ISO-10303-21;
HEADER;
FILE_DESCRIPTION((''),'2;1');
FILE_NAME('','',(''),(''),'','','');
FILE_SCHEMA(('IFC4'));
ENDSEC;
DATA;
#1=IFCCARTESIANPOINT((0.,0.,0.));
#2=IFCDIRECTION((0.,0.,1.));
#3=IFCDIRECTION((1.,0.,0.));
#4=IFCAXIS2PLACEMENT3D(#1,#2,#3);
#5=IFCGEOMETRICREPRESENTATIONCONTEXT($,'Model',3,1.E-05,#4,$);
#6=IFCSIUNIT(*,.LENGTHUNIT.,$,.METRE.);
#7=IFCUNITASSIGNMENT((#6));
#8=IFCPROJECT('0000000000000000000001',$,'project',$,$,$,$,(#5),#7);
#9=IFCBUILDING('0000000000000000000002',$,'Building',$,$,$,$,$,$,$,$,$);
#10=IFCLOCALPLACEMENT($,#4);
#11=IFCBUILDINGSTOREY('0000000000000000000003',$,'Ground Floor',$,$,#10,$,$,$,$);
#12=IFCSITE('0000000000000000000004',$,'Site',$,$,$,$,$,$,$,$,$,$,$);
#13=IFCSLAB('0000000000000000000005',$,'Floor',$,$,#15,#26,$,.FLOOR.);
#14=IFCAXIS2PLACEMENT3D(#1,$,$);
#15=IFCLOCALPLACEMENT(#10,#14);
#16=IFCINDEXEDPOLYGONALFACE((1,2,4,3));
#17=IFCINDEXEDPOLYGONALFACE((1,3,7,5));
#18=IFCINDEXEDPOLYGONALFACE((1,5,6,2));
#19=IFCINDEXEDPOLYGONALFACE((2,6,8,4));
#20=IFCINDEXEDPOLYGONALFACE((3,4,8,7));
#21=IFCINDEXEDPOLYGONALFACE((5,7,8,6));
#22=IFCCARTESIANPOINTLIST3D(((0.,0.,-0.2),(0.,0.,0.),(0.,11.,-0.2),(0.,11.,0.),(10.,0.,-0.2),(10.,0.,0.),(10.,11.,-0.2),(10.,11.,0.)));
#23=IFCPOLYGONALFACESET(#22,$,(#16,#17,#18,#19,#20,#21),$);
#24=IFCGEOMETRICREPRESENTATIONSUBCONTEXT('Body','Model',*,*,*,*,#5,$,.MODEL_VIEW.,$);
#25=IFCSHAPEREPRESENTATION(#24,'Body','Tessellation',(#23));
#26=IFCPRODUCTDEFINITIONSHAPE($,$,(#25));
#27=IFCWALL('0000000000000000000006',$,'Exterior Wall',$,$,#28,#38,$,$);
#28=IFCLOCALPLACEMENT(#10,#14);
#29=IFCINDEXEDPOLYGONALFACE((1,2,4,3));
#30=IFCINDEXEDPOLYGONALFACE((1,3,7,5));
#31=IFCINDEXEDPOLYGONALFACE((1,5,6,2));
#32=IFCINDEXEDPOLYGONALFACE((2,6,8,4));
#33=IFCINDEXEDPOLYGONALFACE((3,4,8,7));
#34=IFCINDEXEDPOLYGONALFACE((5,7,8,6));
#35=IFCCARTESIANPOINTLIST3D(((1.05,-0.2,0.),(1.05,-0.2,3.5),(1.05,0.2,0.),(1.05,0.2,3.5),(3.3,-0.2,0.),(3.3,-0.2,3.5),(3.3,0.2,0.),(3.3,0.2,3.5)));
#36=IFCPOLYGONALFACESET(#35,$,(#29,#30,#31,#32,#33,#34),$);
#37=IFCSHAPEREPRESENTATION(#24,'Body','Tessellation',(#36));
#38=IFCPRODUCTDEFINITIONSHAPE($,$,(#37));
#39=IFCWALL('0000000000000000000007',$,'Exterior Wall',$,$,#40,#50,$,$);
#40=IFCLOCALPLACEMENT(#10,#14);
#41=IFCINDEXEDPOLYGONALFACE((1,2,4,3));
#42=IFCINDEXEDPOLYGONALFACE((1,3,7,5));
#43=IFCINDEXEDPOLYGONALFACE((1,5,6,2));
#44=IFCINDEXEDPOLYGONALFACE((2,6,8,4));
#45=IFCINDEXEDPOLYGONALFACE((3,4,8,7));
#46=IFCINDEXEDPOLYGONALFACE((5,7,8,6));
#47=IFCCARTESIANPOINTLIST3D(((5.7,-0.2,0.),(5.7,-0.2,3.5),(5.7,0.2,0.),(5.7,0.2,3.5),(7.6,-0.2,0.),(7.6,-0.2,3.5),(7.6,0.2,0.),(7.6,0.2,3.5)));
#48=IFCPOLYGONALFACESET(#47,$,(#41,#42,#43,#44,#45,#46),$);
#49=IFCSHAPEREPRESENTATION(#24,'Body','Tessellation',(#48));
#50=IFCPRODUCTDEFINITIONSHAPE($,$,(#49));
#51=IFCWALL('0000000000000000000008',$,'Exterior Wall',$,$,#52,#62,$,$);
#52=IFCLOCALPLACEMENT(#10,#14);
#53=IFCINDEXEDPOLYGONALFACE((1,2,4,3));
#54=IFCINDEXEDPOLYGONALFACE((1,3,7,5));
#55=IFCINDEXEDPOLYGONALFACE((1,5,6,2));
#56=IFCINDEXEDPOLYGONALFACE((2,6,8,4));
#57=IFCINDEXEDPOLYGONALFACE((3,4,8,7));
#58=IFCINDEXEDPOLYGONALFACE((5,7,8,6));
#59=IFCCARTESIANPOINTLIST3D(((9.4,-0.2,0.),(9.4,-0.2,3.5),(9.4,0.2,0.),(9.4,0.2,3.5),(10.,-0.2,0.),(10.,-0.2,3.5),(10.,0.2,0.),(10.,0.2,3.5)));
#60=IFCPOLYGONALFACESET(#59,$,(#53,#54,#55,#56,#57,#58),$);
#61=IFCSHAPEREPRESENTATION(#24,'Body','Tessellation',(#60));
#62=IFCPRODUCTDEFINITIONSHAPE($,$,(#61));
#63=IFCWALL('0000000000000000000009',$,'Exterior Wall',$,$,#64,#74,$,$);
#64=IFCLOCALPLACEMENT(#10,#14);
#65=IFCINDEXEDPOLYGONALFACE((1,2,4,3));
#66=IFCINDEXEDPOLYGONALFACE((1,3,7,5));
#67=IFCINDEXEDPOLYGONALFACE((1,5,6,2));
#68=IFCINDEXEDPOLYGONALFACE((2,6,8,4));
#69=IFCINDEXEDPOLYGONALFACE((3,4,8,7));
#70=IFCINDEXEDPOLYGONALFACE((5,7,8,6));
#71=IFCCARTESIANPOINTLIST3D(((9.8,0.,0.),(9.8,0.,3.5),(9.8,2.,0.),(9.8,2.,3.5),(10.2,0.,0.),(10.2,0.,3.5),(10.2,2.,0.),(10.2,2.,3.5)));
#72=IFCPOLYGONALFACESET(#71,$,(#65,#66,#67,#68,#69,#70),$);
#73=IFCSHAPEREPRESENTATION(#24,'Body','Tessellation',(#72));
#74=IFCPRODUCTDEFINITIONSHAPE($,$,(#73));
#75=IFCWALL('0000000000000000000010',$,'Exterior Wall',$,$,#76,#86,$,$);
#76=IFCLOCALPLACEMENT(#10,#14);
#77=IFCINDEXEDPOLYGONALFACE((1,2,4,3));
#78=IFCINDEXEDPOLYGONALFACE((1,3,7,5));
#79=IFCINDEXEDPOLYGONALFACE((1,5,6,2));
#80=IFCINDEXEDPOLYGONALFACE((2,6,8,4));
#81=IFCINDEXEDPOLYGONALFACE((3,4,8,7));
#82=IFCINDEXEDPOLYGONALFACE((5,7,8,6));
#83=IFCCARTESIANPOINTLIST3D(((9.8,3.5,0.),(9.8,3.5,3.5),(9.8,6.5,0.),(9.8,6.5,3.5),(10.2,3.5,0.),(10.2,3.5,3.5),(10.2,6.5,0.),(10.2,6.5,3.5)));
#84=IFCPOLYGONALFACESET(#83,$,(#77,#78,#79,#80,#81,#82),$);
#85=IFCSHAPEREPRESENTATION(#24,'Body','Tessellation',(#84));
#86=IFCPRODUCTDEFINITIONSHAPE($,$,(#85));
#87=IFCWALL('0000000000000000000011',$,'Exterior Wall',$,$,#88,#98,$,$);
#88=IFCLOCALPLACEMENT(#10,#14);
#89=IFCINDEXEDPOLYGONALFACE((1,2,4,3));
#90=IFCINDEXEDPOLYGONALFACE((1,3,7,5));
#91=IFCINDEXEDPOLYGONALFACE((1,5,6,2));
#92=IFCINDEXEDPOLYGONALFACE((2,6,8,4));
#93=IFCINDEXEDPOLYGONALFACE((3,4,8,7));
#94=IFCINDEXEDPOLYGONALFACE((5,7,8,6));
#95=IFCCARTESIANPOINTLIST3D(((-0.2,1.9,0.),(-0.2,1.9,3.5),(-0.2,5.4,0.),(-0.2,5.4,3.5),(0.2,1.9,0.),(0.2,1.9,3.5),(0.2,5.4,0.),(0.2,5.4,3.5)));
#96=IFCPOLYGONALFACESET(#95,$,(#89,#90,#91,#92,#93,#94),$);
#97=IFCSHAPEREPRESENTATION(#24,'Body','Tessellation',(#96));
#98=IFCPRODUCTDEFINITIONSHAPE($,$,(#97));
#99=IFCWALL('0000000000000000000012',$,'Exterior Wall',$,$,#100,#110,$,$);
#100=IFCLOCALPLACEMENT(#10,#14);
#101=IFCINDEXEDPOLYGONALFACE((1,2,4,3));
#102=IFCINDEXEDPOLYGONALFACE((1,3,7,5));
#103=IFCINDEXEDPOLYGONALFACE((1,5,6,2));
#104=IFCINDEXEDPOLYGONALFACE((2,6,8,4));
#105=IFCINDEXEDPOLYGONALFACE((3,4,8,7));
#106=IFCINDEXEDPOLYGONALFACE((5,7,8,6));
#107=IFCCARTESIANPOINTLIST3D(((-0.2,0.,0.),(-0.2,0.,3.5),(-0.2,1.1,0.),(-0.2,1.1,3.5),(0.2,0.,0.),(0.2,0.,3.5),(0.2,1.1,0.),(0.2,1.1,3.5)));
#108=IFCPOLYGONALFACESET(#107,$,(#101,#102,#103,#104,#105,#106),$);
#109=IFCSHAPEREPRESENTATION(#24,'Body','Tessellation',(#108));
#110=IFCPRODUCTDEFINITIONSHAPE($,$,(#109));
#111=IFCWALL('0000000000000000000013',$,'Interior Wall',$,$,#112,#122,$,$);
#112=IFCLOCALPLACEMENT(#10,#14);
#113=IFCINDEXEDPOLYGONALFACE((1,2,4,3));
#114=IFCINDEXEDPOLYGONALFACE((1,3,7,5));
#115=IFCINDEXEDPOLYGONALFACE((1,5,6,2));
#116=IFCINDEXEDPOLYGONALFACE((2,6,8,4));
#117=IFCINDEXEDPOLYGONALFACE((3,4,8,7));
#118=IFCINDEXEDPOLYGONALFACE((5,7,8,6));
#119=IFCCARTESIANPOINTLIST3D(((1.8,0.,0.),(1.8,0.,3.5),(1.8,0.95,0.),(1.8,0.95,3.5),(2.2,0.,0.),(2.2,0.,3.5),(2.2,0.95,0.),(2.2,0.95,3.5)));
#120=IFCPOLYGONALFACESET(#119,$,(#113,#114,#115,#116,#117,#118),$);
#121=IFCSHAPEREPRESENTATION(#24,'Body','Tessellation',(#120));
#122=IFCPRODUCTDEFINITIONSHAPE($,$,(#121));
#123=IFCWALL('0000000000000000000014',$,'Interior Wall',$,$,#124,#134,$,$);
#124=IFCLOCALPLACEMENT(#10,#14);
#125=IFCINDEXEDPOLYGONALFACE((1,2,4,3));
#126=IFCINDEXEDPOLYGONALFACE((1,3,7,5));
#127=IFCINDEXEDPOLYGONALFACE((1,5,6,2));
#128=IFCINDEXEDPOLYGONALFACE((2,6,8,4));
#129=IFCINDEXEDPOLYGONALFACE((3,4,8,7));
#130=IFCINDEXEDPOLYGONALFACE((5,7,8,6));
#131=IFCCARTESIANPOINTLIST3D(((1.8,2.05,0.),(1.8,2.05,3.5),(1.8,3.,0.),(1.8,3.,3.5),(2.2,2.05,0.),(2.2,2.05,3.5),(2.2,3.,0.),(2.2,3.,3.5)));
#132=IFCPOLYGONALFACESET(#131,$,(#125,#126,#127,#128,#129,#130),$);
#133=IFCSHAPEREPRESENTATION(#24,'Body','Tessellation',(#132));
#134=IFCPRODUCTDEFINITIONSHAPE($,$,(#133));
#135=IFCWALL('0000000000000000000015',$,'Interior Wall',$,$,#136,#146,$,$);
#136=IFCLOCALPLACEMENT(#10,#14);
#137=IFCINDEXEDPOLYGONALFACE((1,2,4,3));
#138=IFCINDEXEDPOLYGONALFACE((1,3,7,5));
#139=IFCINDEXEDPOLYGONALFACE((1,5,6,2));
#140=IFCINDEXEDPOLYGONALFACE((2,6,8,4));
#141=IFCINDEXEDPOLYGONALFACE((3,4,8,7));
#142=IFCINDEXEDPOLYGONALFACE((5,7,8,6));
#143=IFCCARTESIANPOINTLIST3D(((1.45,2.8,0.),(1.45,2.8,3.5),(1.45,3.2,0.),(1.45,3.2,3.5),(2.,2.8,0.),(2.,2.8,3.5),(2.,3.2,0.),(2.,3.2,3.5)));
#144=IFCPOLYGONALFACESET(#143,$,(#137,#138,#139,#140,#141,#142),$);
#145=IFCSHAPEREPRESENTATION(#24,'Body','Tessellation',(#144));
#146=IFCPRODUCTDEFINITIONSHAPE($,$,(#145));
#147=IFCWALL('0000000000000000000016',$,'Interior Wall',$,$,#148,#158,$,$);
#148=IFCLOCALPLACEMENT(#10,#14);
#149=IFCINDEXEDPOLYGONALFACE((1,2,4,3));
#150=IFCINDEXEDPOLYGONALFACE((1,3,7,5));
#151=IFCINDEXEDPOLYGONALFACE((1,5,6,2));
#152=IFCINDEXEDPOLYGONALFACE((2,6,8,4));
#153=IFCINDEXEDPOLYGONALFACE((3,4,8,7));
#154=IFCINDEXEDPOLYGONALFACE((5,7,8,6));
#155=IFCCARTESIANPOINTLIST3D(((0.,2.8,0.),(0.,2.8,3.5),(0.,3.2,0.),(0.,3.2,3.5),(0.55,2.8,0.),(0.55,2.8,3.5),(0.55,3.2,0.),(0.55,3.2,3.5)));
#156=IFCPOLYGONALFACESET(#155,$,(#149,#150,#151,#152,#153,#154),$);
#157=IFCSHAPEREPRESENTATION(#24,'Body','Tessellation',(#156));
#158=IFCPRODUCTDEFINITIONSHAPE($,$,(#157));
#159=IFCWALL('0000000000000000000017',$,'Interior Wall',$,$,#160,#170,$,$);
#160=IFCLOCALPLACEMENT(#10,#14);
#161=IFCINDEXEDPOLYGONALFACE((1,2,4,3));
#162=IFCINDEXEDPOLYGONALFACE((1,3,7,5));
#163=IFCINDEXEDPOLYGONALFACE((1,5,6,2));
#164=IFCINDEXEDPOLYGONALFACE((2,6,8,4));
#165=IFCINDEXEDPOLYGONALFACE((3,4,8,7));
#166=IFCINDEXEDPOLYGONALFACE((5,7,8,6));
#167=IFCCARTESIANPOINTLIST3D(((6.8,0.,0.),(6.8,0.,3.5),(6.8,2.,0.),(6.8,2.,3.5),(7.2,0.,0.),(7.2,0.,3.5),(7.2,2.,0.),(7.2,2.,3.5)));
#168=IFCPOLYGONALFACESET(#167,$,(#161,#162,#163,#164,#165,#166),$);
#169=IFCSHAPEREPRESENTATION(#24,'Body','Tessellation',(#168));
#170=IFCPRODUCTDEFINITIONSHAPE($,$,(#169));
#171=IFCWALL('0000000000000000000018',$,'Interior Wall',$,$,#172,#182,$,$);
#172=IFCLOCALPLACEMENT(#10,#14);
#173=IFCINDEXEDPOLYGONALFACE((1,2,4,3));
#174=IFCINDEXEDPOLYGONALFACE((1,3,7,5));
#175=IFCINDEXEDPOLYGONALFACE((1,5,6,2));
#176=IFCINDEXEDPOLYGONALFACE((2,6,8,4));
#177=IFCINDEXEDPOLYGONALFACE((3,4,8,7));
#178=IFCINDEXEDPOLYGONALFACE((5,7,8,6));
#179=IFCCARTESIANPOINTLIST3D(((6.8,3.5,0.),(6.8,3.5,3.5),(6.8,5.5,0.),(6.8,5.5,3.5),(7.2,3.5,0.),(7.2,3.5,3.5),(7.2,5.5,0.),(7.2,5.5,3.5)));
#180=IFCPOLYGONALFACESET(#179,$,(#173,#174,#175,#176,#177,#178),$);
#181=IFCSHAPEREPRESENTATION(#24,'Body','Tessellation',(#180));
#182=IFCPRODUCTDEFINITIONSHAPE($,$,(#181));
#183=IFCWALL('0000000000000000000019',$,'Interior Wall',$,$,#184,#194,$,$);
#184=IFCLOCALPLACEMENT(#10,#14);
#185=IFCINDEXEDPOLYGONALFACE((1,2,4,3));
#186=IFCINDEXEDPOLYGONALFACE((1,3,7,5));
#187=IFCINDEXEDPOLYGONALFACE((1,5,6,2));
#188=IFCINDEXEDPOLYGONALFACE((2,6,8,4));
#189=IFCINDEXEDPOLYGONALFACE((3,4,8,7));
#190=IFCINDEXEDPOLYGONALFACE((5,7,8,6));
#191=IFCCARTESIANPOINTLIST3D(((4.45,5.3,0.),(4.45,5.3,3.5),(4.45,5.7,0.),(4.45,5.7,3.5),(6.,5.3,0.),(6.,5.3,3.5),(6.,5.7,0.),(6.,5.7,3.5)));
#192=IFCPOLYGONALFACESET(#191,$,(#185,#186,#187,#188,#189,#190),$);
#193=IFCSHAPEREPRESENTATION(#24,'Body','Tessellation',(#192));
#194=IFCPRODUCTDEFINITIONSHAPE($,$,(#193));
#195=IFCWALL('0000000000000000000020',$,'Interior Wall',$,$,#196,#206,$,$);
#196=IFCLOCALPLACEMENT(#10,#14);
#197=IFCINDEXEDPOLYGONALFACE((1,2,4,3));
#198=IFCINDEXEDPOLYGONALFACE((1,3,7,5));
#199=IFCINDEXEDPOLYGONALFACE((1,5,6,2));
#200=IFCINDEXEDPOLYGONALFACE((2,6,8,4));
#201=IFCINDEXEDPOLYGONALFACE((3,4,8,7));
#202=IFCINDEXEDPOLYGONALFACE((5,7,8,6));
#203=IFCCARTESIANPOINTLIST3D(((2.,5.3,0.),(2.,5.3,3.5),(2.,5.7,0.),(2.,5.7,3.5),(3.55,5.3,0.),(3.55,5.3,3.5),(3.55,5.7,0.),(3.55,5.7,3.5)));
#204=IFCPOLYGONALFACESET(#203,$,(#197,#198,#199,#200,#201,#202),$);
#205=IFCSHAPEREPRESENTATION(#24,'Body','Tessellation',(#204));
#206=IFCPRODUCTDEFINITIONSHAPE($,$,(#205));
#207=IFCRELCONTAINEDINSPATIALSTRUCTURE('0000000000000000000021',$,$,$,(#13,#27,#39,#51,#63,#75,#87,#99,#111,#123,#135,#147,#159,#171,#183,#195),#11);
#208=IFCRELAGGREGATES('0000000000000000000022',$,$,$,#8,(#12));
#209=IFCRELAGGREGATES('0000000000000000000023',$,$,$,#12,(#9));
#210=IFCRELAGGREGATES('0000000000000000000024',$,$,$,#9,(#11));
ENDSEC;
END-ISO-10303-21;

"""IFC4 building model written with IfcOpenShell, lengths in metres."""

from ifc_helpers import new_model, si_unit, frame, origin_with_axes, place, context, subcontext, project, spatial, indexed_curve, outline, extrude, element, save


model = new_model("IFC4")

# Units and contexts
model_context = context("Model", 3, precision=1e-05, world=origin_with_axes())
body_context = subcontext(model_context, "Body", "Model", "MODEL_VIEW")
ifc_project = project(units=[si_unit("LENGTHUNIT", "METRE")], contexts=[model_context])

# Site, building, storey
site = spatial("IfcSite", under=ifc_project, Name="Site")
building = spatial("IfcBuilding", under=site, Name="Building")
storey_placement = place(None, origin_with_axes())
storey = spatial("IfcBuildingStorey", under=building, at=storey_placement, Name="Ground Floor")

# Slab
slab_placement = place(storey_placement, frame((0.0, 0.0, -0.2), z_axis=(0.0, 0.0, 1.0), x_axis=(1.0, 0.0, 0.0)))
element("IfcSlab", 1, at=slab_placement, inside=storey, Name="Floor", PredefinedType="FLOOR", context=body_context, shape_type="SweptSolid", body=[
    extrude(outline(indexed_curve([(0.0, 0.0), (10.0, 0.0), (10.0, 11.0), (0.0, 11.0)])), None, (0.0, 0.0, 1.0), 0.2),
])

# Walls
wall_1_placement = place(storey_placement, frame((1.05, 0.0, 0.0), z_axis=(0.0, 0.0, 1.0), x_axis=(1.0, 0.0, 0.0)))
element("IfcWall", 2, at=wall_1_placement, inside=storey, Name="Exterior Wall", context=body_context, shape_type="SweptSolid", body=[
    extrude(outline(indexed_curve([(0.0, 0.0), (0.0, 0.4), (2.25, 0.4), (2.25, 0.0), (0.0, 0.0)], self_intersect=False)), frame((0.0, -0.2, 0.0), z_axis=(0.0, 0.0, 1.0), x_axis=(1.0, 0.0, 0.0)), (0.0, 0.0, 1.0), 3.5),
])
wall_2_placement = place(storey_placement, frame((5.7, 0.0, 0.0), z_axis=(0.0, 0.0, 1.0), x_axis=(1.0, 0.0, 0.0)))
element("IfcWall", 3, at=wall_2_placement, inside=storey, Name="Exterior Wall", context=body_context, shape_type="SweptSolid", body=[
    extrude(outline(indexed_curve([(0.0, 0.0), (0.0, 0.4), (1.9, 0.4), (1.9, 0.0), (0.0, 0.0)], self_intersect=False)), frame((0.0, -0.2, 0.0), z_axis=(0.0, 0.0, 1.0), x_axis=(1.0, 0.0, 0.0)), (0.0, 0.0, 1.0), 3.5),
])
wall_3_placement = place(storey_placement, frame((9.4, 0.0, 0.0), z_axis=(0.0, 0.0, 1.0), x_axis=(1.0, 0.0, 0.0)))
element("IfcWall", 4, at=wall_3_placement, inside=storey, Name="Exterior Wall", context=body_context, shape_type="SweptSolid", body=[
    extrude(outline(indexed_curve([(0.0, 0.0), (0.0, 0.4), (0.6, 0.4), (0.6, 0.0), (0.0, 0.0)], self_intersect=False)), frame((0.0, -0.2, 0.0), z_axis=(0.0, 0.0, 1.0), x_axis=(1.0, 0.0, 0.0)), (0.0, 0.0, 1.0), 3.5),
])
wall_4_placement = place(storey_placement, frame((10.0, 0.0, 0.0), z_axis=(0.0, 0.0, 1.0), x_axis=(0.0, 1.0, 0.0)))
element("IfcWall", 5, at=wall_4_placement, inside=storey, Name="Exterior Wall", context=body_context, shape_type="SweptSolid", body=[
    extrude(outline(indexed_curve([(0.0, 0.0), (0.0, 0.4), (2.0, 0.4), (2.0, 0.0), (0.0, 0.0)], self_intersect=False)), frame((0.0, -0.2, 0.0), z_axis=(0.0, 0.0, 1.0), x_axis=(1.0, 0.0, 0.0)), (0.0, 0.0, 1.0), 3.5),
])
wall_5_placement = place(storey_placement, frame((10.0, 3.5, 0.0), z_axis=(0.0, 0.0, 1.0), x_axis=(0.0, 1.0, 0.0)))
element("IfcWall", 6, at=wall_5_placement, inside=storey, Name="Exterior Wall", context=body_context, shape_type="SweptSolid", body=[
    extrude(outline(indexed_curve([(0.0, 0.0), (0.0, 0.4), (3.0, 0.4), (3.0, 0.0), (0.0, 0.0)], self_intersect=False)), frame((0.0, -0.2, 0.0), z_axis=(0.0, 0.0, 1.0), x_axis=(1.0, 0.0, 0.0)), (0.0, 0.0, 1.0), 3.5),
])
wall_6_placement = place(storey_placement, frame((0.0, 5.4, 0.0), z_axis=(0.0, 0.0, 1.0), x_axis=(0.0, -1.0, 0.0)))
element("IfcWall", 7, at=wall_6_placement, inside=storey, Name="Exterior Wall", context=body_context, shape_type="SweptSolid", body=[
    extrude(outline(indexed_curve([(0.0, 0.0), (0.0, 0.4), (3.5, 0.4), (3.5, 0.0), (0.0, 0.0)], self_intersect=False)), frame((0.0, -0.2, 0.0), z_axis=(0.0, 0.0, 1.0), x_axis=(1.0, 0.0, 0.0)), (0.0, 0.0, 1.0), 3.5),
])
wall_7_placement = place(storey_placement, frame((0.0, 1.1, 0.0), z_axis=(0.0, 0.0, 1.0), x_axis=(0.0, -1.0, 0.0)))
element("IfcWall", 8, at=wall_7_placement, inside=storey, Name="Exterior Wall", context=body_context, shape_type="SweptSolid", body=[
    extrude(outline(indexed_curve([(0.0, 0.0), (0.0, 0.4), (1.1, 0.4), (1.1, 0.0), (0.0, 0.0)], self_intersect=False)), frame((0.0, -0.2, 0.0), z_axis=(0.0, 0.0, 1.0), x_axis=(1.0, 0.0, 0.0)), (0.0, 0.0, 1.0), 3.5),
])
wall_8_placement = place(storey_placement, frame((2.0, 0.0, 0.0), z_axis=(0.0, 0.0, 1.0), x_axis=(0.0, 1.0, 0.0)))
element("IfcWall", 9, at=wall_8_placement, inside=storey, Name="Interior Wall", context=body_context, shape_type="SweptSolid", body=[
    extrude(outline(indexed_curve([(0.0, 0.0), (0.0, 0.4), (0.95, 0.4), (0.95, 0.0), (0.0, 0.0)], self_intersect=False)), frame((0.0, -0.2, 0.0), z_axis=(0.0, 0.0, 1.0), x_axis=(1.0, 0.0, 0.0)), (0.0, 0.0, 1.0), 3.5),
])
wall_9_placement = place(storey_placement, frame((2.0, 2.05, 0.0), z_axis=(0.0, 0.0, 1.0), x_axis=(0.0, 1.0, 0.0)))
element("IfcWall", 10, at=wall_9_placement, inside=storey, Name="Interior Wall", context=body_context, shape_type="SweptSolid", body=[
    extrude(outline(indexed_curve([(0.0, 0.0), (0.0, 0.4), (0.95, 0.4), (0.95, 0.0), (0.0, 0.0)], self_intersect=False)), frame((0.0, -0.2, 0.0), z_axis=(0.0, 0.0, 1.0), x_axis=(1.0, 0.0, 0.0)), (0.0, 0.0, 1.0), 3.5),
])
for number, where, z_axis, x_axis, name in (
    (11, (2.0, 3.0, 0.0), (0.0, 0.0, 1.0), (-1.0, 0.0, 0.0), "Interior Wall"),
    (12, (0.55, 3.0, 0.0), (0.0, 0.0, 1.0), (-1.0, 0.0, 0.0), "Interior Wall"),
):
    element("IfcWall", number, at=place(storey_placement, frame(where, z_axis=z_axis, x_axis=x_axis)), inside=storey, Name=name, context=body_context, shape_type="SweptSolid", body=[
        extrude(outline(indexed_curve([(0.0, 0.0), (0.0, 0.4), (0.55, 0.4), (0.55, 0.0), (0.0, 0.0)], self_intersect=False)), frame((0.0, -0.2, 0.0), z_axis=(0.0, 0.0, 1.0), x_axis=(1.0, 0.0, 0.0)), (0.0, 0.0, 1.0), 3.5),
    ])
for number, where, z_axis, x_axis, name in (
    (13, (7.0, 0.0, 0.0), (0.0, 0.0, 1.0), (0.0, 1.0, 0.0), "Interior Wall"),
    (14, (7.0, 3.5, 0.0), (0.0, 0.0, 1.0), (0.0, 1.0, 0.0), "Interior Wall"),
):
    element("IfcWall", number, at=place(storey_placement, frame(where, z_axis=z_axis, x_axis=x_axis)), inside=storey, Name=name, context=body_context, shape_type="SweptSolid", body=[
        extrude(outline(indexed_curve([(0.0, 0.0), (0.0, 0.4), (2.0, 0.4), (2.0, 0.0), (0.0, 0.0)], self_intersect=False)), frame((0.0, -0.2, 0.0), z_axis=(0.0, 0.0, 1.0), x_axis=(1.0, 0.0, 0.0)), (0.0, 0.0, 1.0), 3.5),
    ])
for number, where, z_axis, x_axis, name in (
    (15, (6.0, 5.5, 0.0), (0.0, 0.0, 1.0), (-1.0, 0.0, 0.0), "Interior Wall"),
    (16, (3.55, 5.5, 0.0), (0.0, 0.0, 1.0), (-1.0, 0.0, 0.0), "Interior Wall"),
):
    element("IfcWall", number, at=place(storey_placement, frame(where, z_axis=z_axis, x_axis=x_axis)), inside=storey, Name=name, context=body_context, shape_type="SweptSolid", body=[
        extrude(outline(indexed_curve([(0.0, 0.0), (0.0, 0.4), (1.55, 0.4), (1.55, 0.0), (0.0, 0.0)], self_intersect=False)), frame((0.0, -0.2, 0.0), z_axis=(0.0, 0.0, 1.0), x_axis=(1.0, 0.0, 0.0)), (0.0, 0.0, 1.0), 3.5),
    ])

save(model, "model.ifc")
